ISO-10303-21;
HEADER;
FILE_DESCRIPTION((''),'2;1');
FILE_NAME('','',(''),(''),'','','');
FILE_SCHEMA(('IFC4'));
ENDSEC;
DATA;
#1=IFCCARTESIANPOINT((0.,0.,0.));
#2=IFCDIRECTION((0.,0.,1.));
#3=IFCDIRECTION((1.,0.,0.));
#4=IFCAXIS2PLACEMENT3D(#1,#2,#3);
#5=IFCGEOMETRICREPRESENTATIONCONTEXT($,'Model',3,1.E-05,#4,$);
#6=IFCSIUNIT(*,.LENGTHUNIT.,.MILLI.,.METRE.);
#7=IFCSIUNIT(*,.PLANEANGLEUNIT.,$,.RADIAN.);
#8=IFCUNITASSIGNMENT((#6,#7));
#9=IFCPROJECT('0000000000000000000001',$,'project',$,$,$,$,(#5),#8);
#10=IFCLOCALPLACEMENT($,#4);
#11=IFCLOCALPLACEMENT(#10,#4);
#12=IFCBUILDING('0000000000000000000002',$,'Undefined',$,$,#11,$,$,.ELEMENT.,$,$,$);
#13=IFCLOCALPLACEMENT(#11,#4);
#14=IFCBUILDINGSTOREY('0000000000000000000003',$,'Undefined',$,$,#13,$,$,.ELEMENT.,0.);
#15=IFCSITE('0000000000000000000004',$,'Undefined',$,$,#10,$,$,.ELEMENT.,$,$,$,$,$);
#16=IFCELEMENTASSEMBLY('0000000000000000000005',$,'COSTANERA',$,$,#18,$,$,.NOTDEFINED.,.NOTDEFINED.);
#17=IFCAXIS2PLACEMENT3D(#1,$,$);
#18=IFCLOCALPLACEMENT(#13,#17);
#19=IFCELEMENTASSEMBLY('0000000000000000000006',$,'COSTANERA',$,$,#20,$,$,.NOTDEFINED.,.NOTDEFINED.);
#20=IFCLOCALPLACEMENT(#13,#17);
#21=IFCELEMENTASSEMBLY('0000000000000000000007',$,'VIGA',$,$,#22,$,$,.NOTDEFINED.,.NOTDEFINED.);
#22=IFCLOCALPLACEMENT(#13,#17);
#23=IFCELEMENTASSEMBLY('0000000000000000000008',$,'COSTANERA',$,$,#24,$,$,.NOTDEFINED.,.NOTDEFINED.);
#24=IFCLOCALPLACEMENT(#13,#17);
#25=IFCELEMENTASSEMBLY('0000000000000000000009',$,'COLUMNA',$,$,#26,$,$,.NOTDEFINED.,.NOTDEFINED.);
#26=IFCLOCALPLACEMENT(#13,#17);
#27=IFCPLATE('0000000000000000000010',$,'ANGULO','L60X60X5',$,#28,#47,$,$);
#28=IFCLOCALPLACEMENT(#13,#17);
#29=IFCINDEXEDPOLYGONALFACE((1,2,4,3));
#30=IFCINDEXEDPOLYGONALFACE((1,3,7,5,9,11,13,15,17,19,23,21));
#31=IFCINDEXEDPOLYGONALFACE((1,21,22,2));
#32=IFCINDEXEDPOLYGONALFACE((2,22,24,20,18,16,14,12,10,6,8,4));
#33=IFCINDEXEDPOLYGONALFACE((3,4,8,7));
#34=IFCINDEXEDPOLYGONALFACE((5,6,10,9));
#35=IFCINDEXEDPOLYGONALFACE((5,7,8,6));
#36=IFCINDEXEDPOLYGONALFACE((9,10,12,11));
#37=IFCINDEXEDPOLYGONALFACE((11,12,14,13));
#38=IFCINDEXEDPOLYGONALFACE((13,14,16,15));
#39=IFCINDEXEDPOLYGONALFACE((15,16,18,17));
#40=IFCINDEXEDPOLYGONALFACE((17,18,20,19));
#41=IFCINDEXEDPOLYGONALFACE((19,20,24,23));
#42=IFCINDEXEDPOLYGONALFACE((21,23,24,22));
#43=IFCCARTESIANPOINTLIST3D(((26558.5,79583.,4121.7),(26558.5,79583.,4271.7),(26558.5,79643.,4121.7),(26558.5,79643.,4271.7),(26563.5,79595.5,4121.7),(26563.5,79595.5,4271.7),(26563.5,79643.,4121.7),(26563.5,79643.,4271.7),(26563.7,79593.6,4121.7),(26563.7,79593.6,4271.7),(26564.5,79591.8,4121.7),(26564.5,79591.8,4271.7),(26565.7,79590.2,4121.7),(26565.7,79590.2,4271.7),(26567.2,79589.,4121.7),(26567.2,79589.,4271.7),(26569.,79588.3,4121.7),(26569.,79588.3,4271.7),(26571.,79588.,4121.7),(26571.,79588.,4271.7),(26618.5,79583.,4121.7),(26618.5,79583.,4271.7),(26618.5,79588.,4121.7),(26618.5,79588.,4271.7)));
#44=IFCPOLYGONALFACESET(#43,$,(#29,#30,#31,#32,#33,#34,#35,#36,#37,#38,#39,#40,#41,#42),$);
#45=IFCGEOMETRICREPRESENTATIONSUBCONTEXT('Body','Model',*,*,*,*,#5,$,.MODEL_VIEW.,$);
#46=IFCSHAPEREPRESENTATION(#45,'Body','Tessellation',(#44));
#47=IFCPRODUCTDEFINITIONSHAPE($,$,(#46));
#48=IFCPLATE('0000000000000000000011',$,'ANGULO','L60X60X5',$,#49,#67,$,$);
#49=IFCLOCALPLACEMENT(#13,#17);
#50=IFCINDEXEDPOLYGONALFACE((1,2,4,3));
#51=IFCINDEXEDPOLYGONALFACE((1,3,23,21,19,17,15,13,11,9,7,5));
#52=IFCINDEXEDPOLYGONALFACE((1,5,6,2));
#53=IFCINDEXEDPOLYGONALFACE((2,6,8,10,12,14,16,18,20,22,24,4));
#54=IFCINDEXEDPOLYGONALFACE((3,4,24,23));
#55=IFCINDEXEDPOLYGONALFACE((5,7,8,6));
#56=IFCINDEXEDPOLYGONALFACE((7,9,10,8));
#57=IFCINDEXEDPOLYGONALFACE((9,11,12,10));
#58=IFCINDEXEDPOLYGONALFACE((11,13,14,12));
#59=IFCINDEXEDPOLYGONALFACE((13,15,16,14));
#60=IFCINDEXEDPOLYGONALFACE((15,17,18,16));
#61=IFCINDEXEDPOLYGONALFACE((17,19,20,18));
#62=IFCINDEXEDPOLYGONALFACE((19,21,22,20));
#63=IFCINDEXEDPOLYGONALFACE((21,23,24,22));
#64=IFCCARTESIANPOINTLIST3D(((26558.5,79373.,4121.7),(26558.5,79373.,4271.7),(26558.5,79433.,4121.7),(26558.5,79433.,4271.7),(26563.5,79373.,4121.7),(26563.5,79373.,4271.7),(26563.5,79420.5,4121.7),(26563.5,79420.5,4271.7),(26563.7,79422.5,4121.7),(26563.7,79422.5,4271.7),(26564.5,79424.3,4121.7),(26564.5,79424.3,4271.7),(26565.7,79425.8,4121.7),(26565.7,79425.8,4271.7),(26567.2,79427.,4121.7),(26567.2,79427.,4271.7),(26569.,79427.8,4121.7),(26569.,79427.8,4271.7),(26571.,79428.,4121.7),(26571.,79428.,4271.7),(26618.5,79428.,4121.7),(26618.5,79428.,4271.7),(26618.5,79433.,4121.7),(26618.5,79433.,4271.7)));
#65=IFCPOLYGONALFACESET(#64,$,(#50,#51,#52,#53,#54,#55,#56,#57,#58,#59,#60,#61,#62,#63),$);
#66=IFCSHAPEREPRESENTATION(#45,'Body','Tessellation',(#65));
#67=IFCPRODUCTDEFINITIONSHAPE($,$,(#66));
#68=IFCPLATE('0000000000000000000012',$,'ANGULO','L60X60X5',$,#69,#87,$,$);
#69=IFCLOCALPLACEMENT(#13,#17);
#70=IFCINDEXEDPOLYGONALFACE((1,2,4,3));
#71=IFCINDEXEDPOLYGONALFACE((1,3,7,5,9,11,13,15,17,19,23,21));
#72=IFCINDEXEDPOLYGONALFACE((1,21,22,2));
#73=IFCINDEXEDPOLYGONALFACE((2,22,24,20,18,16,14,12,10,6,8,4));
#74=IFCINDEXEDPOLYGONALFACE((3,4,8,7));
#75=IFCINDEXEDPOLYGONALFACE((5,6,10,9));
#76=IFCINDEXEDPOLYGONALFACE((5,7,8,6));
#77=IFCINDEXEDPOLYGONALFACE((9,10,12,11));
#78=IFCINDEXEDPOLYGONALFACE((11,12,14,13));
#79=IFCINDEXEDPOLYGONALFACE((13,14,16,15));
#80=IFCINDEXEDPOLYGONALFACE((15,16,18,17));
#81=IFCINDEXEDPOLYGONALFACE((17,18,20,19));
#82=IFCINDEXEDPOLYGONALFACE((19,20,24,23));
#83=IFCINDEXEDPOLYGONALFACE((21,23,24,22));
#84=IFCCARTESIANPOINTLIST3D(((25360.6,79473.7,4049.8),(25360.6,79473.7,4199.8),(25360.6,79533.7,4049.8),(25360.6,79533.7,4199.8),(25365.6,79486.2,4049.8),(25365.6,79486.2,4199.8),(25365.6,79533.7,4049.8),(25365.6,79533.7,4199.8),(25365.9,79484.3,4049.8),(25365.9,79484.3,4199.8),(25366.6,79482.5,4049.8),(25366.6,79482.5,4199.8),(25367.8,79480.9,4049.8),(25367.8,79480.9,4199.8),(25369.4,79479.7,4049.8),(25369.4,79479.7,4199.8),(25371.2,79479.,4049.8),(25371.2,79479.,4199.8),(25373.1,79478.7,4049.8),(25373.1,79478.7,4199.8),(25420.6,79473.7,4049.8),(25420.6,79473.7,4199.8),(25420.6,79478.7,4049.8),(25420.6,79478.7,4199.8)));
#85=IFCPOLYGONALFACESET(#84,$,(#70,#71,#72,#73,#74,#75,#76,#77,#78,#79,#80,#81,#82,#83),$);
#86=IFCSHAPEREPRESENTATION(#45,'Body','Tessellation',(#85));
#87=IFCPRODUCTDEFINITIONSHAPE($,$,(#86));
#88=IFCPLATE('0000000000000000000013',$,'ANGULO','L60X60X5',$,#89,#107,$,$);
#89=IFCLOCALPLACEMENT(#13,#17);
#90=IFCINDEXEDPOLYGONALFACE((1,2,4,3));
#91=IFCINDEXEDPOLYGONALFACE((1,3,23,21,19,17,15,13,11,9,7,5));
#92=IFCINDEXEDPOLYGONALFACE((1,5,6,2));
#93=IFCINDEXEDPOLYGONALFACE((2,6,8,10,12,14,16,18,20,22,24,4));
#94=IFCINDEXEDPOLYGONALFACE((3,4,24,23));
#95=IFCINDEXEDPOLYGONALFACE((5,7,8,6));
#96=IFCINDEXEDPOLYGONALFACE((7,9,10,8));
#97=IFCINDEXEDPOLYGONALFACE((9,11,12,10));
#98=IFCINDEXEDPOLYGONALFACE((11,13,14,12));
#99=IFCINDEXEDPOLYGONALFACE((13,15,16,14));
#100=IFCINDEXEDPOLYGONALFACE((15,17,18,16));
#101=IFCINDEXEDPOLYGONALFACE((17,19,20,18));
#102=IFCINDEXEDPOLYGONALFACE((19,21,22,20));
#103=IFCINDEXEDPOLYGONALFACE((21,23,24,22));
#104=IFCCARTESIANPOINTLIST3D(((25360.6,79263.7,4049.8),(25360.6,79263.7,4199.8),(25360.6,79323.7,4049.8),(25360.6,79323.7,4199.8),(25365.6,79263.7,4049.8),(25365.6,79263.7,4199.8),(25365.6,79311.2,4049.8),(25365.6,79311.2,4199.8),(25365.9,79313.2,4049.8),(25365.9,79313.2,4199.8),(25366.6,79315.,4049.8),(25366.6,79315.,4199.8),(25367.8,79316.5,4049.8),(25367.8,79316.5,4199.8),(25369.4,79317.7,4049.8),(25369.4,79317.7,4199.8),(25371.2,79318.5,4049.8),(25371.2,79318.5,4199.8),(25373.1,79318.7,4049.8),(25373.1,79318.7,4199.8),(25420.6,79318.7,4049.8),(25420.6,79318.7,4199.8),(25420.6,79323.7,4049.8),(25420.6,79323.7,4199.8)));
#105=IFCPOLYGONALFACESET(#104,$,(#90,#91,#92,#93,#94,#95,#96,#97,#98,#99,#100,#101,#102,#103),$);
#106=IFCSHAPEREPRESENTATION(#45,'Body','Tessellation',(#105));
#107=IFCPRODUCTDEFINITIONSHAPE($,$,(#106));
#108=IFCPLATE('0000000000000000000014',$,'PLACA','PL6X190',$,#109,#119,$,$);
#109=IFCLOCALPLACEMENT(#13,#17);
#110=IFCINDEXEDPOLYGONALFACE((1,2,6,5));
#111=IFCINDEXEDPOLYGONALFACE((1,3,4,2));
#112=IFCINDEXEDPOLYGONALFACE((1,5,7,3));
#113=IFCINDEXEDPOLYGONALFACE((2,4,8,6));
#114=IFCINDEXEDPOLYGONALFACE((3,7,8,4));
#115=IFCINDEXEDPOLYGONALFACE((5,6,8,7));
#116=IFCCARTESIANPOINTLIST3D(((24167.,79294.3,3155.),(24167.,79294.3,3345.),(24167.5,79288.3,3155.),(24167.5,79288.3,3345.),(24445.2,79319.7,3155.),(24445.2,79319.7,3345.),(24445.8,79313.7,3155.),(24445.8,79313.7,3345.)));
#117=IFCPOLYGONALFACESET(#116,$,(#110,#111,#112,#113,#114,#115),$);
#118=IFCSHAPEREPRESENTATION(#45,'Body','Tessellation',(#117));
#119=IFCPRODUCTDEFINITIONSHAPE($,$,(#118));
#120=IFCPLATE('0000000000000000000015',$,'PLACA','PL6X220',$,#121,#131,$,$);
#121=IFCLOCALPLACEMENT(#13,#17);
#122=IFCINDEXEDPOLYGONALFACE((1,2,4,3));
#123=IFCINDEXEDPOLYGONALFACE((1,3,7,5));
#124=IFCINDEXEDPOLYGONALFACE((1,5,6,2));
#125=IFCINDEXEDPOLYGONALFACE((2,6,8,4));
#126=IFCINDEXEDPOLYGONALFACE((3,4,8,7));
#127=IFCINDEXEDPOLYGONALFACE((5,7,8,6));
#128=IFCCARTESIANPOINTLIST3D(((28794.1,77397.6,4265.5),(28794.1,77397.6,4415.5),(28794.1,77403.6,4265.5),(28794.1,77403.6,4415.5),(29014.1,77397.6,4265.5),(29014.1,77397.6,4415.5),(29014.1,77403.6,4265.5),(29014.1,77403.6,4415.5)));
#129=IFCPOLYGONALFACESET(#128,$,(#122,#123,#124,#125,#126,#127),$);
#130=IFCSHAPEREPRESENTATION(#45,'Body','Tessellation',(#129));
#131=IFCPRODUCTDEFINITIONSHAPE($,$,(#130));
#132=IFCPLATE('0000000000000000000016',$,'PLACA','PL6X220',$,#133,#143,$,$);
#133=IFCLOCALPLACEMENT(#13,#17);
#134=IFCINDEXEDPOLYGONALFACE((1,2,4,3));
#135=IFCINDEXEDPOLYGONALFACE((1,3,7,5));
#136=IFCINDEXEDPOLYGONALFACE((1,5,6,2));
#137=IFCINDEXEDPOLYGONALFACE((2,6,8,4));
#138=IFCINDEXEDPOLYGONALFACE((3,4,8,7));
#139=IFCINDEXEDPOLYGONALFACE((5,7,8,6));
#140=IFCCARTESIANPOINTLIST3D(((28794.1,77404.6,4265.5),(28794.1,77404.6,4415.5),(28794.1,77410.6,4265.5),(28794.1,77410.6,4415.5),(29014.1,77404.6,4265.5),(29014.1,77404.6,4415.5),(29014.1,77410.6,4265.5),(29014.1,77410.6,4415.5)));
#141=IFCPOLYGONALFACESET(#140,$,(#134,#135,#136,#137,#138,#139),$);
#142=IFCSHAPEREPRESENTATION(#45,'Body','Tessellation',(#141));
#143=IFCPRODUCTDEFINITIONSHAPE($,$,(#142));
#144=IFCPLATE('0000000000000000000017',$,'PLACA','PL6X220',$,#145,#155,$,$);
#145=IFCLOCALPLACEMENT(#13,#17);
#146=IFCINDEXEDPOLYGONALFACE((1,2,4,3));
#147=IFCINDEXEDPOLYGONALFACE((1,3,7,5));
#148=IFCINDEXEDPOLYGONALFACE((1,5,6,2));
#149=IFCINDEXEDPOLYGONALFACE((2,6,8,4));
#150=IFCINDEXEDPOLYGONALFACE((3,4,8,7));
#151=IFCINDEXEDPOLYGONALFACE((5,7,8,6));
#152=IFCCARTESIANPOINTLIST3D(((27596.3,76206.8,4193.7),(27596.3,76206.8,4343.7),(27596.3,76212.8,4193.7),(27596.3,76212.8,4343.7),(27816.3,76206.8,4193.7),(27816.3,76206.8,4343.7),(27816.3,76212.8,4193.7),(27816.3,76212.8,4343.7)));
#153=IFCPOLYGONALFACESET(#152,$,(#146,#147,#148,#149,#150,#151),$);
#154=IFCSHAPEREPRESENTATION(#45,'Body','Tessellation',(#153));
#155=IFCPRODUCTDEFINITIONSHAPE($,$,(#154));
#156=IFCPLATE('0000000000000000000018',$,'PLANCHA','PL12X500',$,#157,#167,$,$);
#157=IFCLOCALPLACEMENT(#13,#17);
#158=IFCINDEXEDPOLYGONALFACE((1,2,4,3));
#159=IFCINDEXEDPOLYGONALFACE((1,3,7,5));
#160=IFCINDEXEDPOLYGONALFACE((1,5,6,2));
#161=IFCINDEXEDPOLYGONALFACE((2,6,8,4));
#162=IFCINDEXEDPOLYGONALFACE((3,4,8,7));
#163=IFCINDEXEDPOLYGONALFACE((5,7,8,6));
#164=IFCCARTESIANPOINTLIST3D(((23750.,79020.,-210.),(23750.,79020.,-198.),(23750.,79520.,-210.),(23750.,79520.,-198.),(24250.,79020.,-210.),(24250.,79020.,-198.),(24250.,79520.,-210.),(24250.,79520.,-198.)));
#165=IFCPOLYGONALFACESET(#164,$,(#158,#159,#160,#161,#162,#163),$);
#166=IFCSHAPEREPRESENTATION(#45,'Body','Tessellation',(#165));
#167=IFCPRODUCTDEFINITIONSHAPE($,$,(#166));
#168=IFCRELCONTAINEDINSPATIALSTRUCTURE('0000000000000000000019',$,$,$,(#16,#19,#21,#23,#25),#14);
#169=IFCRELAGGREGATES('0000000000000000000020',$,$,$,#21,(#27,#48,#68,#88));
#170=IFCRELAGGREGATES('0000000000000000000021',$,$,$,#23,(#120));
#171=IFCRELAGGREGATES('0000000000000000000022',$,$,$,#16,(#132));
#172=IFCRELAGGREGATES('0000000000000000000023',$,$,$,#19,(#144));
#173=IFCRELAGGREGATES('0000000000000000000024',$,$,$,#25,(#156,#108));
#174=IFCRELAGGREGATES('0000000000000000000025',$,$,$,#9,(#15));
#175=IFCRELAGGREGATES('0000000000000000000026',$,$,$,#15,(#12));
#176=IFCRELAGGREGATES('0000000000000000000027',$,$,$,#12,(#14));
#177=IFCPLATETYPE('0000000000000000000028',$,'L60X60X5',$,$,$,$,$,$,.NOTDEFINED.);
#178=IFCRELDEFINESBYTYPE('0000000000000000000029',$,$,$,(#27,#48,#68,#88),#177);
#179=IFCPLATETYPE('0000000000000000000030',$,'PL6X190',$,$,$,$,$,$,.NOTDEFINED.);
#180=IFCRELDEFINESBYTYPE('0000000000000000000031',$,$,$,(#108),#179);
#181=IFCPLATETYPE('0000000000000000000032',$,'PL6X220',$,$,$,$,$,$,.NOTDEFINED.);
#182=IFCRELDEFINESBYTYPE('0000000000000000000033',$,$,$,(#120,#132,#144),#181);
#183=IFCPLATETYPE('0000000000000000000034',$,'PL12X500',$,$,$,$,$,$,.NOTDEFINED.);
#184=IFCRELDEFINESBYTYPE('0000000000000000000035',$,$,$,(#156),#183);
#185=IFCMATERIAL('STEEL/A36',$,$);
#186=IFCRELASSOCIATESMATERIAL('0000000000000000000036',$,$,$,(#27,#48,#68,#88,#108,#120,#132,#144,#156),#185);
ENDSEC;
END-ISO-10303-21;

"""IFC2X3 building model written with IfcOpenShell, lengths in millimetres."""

from ifc_helpers import new_model, si_unit, frame, origin_with_axes, origin_2d_with_axis, place, context, subcontext, project, spatial, polyline, l_section, outline, extrude, material, type_object, element, aggregate, save


model = new_model("IFC2X3")

# Units and contexts
model_context = context("Model", 3, precision=1e-05, world=origin_with_axes())
body_context = subcontext(model_context, "Body", "Model", "MODEL_VIEW")
ifc_project = project(units=[si_unit("LENGTHUNIT", "METRE", prefix="MILLI"), si_unit("PLANEANGLEUNIT", "RADIAN")], contexts=[model_context])

# Site, building, storey
site_placement = place(None, origin_with_axes())
site = spatial("IfcSite", under=ifc_project, at=site_placement, Name="Undefined", CompositionType="ELEMENT")
building_placement = place(site_placement, origin_with_axes())
building = spatial("IfcBuilding", under=site, at=building_placement, Name="Undefined", CompositionType="ELEMENT")
storey_placement = place(building_placement, origin_with_axes())
storey = spatial("IfcBuildingStorey", under=building, at=storey_placement, Name="Undefined", CompositionType="ELEMENT", Elevation=0.0)

# Element assemblies
assembly_1_placement = place(storey_placement, origin_with_axes())
assembly_1 = element("IfcElementAssembly", 1, at=assembly_1_placement, inside=storey, Name="COSTANERA", AssemblyPlace="NOTDEFINED", PredefinedType="NOTDEFINED")
ifc_material_1 = material(Name="STEEL/A36")
assembly_2_placement = place(storey_placement, origin_with_axes())
assembly_2 = element("IfcElementAssembly", 2, at=assembly_2_placement, inside=storey, Name="COSTANERA", AssemblyPlace="NOTDEFINED", PredefinedType="NOTDEFINED")

# Element assemblies
assembly_3_placement = place(storey_placement, origin_with_axes())
assembly_3 = element("IfcElementAssembly", 3, at=assembly_3_placement, inside=storey, Name="VIGA", AssemblyPlace="NOTDEFINED", PredefinedType="NOTDEFINED")
assembly_4_placement = place(storey_placement, origin_with_axes())
assembly_4 = element("IfcElementAssembly", 4, at=assembly_4_placement, inside=storey, Name="COSTANERA", AssemblyPlace="NOTDEFINED", PredefinedType="NOTDEFINED")

# Element assembly
assembly_5_placement = place(storey_placement, origin_with_axes())
assembly_5 = element("IfcElementAssembly", 5, at=assembly_5_placement, inside=storey, Name="COLUMNA", AssemblyPlace="NOTDEFINED", PredefinedType="NOTDEFINED")

# Plates
plate_type_1 = type_object("IfcPlateType", Name="L60X60X5", PredefinedType="NOTDEFINED")
plate_1_placement = place(assembly_3_placement, frame((26588.5, 79613.0, 4121.7), z_axis=(1.0, 0.0, 0.0), x_axis=(0.0, 0.0, 1.0)))
plate_1 = element("IfcPlate", 6, at=plate_1_placement, type_object=plate_type_1, material=ifc_material_1, Name="ANGULO", Description="L60X60X5", context=body_context, shape_type="SweptSolid", body=[
    extrude(l_section(Depth=60.0, Width=60.0, Thickness=5.0, FilletRadius=7.5, at=origin_2d_with_axis()), frame((150.0, 0.0, 0.0), z_axis=(-1.0, 0.0, 0.0), x_axis=(0.0, -1.0, 0.0)), (0.0, 0.0, 1.0), 150.0),
])
plate_2_placement = place(assembly_3_placement, frame((26588.5, 79403.0, 4271.7), z_axis=(1.0, 0.0, 0.0), x_axis=(0.0, 0.0, -1.0)))
plate_2 = element("IfcPlate", 7, at=plate_2_placement, type_object=plate_type_1, material=ifc_material_1, Name="ANGULO", Description="L60X60X5", context=body_context, shape_type="SweptSolid", body=[
    extrude(l_section(Depth=60.0, Width=60.0, Thickness=5.0, FilletRadius=7.5, at=origin_2d_with_axis()), frame((150.0, 0.0, 0.0), z_axis=(-1.0, 0.0, 0.0), x_axis=(0.0, -1.0, 0.0)), (0.0, 0.0, 1.0), 150.0),
])
plate_3_placement = place(assembly_3_placement, frame((25390.6, 79503.7, 4049.8), z_axis=(1.0, 0.0, 0.0), x_axis=(0.0, 0.0, 1.0)))
plate_3 = element("IfcPlate", 8, at=plate_3_placement, type_object=plate_type_1, material=ifc_material_1, Name="ANGULO", Description="L60X60X5", context=body_context, shape_type="SweptSolid", body=[
    extrude(l_section(Depth=60.0, Width=60.0, Thickness=5.0, FilletRadius=7.5, at=origin_2d_with_axis()), frame((150.0, 0.0, 0.0), z_axis=(-1.0, 0.0, 0.0), x_axis=(0.0, -1.0, 0.0)), (0.0, 0.0, 1.0), 150.0),
])
plate_4_placement = place(assembly_3_placement, frame((25390.6, 79293.7, 4199.8), z_axis=(1.0, 0.0, 0.0), x_axis=(0.0, 0.0, -1.0)))
plate_4 = element("IfcPlate", 9, at=plate_4_placement, type_object=plate_type_1, material=ifc_material_1, Name="ANGULO", Description="L60X60X5", context=body_context, shape_type="SweptSolid", body=[
    extrude(l_section(Depth=60.0, Width=60.0, Thickness=5.0, FilletRadius=7.5, at=origin_2d_with_axis()), frame((150.0, 0.0, 0.0), z_axis=(-1.0, 0.0, 0.0), x_axis=(0.0, -1.0, 0.0)), (0.0, 0.0, 1.0), 150.0),
])
aggregate(assembly_3, [plate_1, plate_2, plate_3, plate_4])
plate_type_2 = type_object("IfcPlateType", Name="PL6X190", PredefinedType="NOTDEFINED")
plate_5_placement = place(assembly_5_placement, frame((24445.5, 79316.7, 3250.0), z_axis=(-0.090876, 0.995862, 0.0), x_axis=(-0.995862, -0.090876, 0.0)))
plate_5 = element("IfcPlate", 10, at=plate_5_placement, type_object=plate_type_2, material=ifc_material_1, Name="PLACA", Description="PL6X190", context=body_context, shape_type="SweptSolid", body=[
    extrude(outline(polyline([(0.0, -95.0), (0.0, 95.0), (279.4, 95.0), (279.4, -95.0), (0.0, -95.0)])), frame((0.0, 0.0, -3.0), z_axis=(0.0, 0.0, 1.0), x_axis=(1.0, 0.0, 0.0)), (0.0, 0.0, 1.0), 6.0),
])
plate_type_3 = type_object("IfcPlateType", Name="PL6X220", PredefinedType="NOTDEFINED")
plate_6_placement = place(assembly_4_placement, frame((28904.1, 77400.6, 4265.5), z_axis=(0.0, -1.0, 0.0), x_axis=(0.0, 0.0, 1.0)))
plate_6 = element("IfcPlate", 11, at=plate_6_placement, type_object=plate_type_3, material=ifc_material_1, Name="PLACA", Description="PL6X220", context=body_context, shape_type="SweptSolid", body=[
    extrude(outline(polyline([(0.0, -110.0), (0.0, 110.0), (150.0, 110.0), (150.0, -110.0), (0.0, -110.0)])), frame((0.0, 0.0, -3.0), z_axis=(0.0, 0.0, 1.0), x_axis=(1.0, 0.0, 0.0)), (0.0, 0.0, 1.0), 6.0),
])
aggregate(assembly_4, [plate_6])
plate_7_placement = place(assembly_1_placement, frame((28904.1, 77407.6, 4265.5), z_axis=(0.0, -1.0, 0.0), x_axis=(0.0, 0.0, 1.0)))
plate_7 = element("IfcPlate", 12, at=plate_7_placement, type_object=plate_type_3, material=ifc_material_1, Name="PLACA", Description="PL6X220", context=body_context, shape_type="SweptSolid", body=[
    extrude(outline(polyline([(0.0, -110.0), (0.0, 110.0), (150.0, 110.0), (150.0, -110.0), (0.0, -110.0)])), frame((0.0, 0.0, -3.0), z_axis=(0.0, 0.0, 1.0), x_axis=(1.0, 0.0, 0.0)), (0.0, 0.0, 1.0), 6.0),
])
aggregate(assembly_1, [plate_7])
plate_8_placement = place(assembly_2_placement, frame((27706.3, 76209.8, 4193.7), z_axis=(0.0, -1.0, 0.0), x_axis=(0.0, 0.0, 1.0)))
plate_8 = element("IfcPlate", 13, at=plate_8_placement, type_object=plate_type_3, material=ifc_material_1, Name="PLACA", Description="PL6X220", context=body_context, shape_type="SweptSolid", body=[
    extrude(outline(polyline([(0.0, -110.0), (0.0, 110.0), (150.0, 110.0), (150.0, -110.0), (0.0, -110.0)])), frame((0.0, 0.0, -3.0), z_axis=(0.0, 0.0, 1.0), x_axis=(1.0, 0.0, 0.0)), (0.0, 0.0, 1.0), 6.0),
])
plate_type_4 = type_object("IfcPlateType", Name="PL12X500", PredefinedType="NOTDEFINED")
plate_9_placement = place(assembly_5_placement, frame((24250.0, 79270.0, -204.0), z_axis=(0.0, 0.0, 1.0), x_axis=(-1.0, 0.0, 0.0)))
plate_9 = element("IfcPlate", 14, at=plate_9_placement, type_object=plate_type_4, material=ifc_material_1, Name="PLANCHA", Description="PL12X500", context=body_context, shape_type="SweptSolid", body=[
    extrude(outline(polyline([(0.0, -250.0), (0.0, 250.0), (500.0, 250.0), (500.0, -250.0), (0.0, -250.0)])), frame((0.0, 0.0, -6.0), z_axis=(0.0, 0.0, 1.0), x_axis=(1.0, 0.0, 0.0)), (0.0, 0.0, 1.0), 12.0),
])

aggregate(assembly_2, [plate_8])

aggregate(assembly_5, [plate_9, plate_5])

save(model, "model.ifc")
